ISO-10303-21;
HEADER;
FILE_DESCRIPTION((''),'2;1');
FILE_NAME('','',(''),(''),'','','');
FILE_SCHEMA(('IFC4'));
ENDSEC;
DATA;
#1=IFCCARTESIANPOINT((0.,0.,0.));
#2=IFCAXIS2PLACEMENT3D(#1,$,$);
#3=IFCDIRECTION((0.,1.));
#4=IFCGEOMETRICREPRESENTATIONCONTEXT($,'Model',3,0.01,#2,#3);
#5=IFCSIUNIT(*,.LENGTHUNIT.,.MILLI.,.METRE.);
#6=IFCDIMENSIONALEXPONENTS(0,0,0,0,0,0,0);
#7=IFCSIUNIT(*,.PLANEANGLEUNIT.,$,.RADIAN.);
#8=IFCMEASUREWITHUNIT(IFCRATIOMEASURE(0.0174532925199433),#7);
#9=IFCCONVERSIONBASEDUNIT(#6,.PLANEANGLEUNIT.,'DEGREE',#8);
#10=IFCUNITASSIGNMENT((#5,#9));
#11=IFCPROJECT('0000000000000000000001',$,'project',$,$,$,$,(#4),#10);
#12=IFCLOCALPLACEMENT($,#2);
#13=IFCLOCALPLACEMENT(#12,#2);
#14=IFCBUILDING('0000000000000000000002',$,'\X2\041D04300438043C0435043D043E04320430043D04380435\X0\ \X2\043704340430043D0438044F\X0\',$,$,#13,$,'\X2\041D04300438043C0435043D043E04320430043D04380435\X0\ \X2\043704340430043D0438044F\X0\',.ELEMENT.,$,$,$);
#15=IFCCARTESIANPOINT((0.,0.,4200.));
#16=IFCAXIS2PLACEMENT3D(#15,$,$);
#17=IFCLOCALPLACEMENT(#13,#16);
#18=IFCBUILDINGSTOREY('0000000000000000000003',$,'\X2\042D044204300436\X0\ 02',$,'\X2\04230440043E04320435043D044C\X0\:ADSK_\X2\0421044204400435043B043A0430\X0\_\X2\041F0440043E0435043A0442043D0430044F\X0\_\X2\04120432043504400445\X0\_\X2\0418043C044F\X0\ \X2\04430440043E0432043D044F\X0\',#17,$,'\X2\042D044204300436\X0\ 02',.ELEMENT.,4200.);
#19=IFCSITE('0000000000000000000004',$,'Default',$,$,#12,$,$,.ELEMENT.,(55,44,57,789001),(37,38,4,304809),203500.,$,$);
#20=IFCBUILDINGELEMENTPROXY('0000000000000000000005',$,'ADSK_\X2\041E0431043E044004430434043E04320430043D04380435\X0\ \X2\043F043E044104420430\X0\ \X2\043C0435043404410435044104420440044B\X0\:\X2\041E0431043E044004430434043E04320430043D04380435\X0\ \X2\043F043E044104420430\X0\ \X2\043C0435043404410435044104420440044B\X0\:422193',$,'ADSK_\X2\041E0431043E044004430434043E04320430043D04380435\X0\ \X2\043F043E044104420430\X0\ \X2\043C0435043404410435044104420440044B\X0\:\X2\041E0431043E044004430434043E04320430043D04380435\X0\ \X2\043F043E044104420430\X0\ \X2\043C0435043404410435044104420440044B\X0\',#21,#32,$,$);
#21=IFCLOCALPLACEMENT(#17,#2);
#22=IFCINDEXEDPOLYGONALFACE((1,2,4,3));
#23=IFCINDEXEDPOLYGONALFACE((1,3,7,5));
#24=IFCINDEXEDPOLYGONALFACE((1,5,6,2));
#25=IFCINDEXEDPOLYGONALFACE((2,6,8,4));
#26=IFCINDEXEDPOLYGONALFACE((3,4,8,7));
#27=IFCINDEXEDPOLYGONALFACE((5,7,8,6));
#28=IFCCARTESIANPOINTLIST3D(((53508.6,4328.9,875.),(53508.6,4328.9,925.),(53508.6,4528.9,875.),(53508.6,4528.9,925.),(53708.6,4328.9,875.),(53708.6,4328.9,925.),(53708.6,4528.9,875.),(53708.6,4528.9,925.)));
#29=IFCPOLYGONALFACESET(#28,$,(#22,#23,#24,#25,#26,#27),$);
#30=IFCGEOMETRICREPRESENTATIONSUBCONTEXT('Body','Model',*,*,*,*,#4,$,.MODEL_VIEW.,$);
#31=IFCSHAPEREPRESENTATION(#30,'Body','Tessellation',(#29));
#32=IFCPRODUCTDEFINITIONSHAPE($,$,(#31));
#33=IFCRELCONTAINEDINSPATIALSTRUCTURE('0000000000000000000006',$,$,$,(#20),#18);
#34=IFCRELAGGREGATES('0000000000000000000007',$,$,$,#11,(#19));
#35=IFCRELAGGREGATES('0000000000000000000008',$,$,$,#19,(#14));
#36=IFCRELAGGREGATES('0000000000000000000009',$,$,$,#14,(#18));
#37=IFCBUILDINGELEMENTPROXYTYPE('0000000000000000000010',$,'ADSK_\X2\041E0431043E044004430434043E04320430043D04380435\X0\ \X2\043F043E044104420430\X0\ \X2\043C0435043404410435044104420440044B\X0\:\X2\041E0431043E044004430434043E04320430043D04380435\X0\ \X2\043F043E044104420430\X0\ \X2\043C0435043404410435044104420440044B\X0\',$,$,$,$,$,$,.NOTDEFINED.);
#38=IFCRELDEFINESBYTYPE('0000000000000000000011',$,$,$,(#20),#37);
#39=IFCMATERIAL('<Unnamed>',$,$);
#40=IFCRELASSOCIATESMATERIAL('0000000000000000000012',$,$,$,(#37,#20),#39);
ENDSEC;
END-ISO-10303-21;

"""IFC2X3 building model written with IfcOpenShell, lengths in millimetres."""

from ifc_helpers import new_model, entity, si_unit, converted_unit, direction, frame, origin, origin_2d_with_axis, place, context, subcontext, project, spatial, rectangle, extrude, source, transform, mapped, material, type_object, type_shapes, element, save


model = new_model("IFC2X3")

# Units and contexts
model_context = context("Model", 3, precision=0.01, world=origin(), true_north=direction((0.0, 1.0)))
body_context = subcontext(model_context, "Body", "Model", "MODEL_VIEW")
ifc_project = project(units=[si_unit("LENGTHUNIT", "METRE", prefix="MILLI"), converted_unit("PLANEANGLEUNIT", "DEGREE", entity("IfcRatioMeasure", 0.0174532925199433), si_unit("PLANEANGLEUNIT", "RADIAN"), dimensions=[0, 0, 0, 0, 0, 0, 0])], contexts=[model_context])

# Site, building, storey
site_placement = place(None, origin())
site = spatial("IfcSite", under=ifc_project, at=site_placement, Name="Default", CompositionType="ELEMENT", RefLatitude=(55, 44, 57, 789001), RefLongitude=(37, 38, 4, 304809), RefElevation=203500.0)
building_placement = place(site_placement, origin())
building = spatial("IfcBuilding", under=site, at=building_placement, Name="Наименование здания", LongName="Наименование здания", CompositionType="ELEMENT")
storey_placement = place(building_placement, frame((0.0, 0.0, 4200.0)))
storey = spatial("IfcBuildingStorey", under=building, at=storey_placement, Name="Этаж 02", ObjectType="Уровень:ADSK_Стрелка_Проектная_Вверх_Имя уровня", LongName="Этаж 02", CompositionType="ELEMENT", Elevation=4200.0)

# Building element proxy
ifc_material_1 = material(Name="<Unnamed>")
building_element_proxy_type_1 = type_object("IfcBuildingElementProxyType", Name="ADSK_Оборудование поста медсестры:Оборудование поста медсестры", PredefinedType="NOTDEFINED", material=ifc_material_1)
shared_shape_1 = source(origin(), body_context, "Body", "SweptSolid", [
    extrude(rectangle(XDim=200.0, YDim=200.0, at=origin_2d_with_axis()), frame((0.0, -68.0, -25.0), z_axis=(0.0, 0.0, 1.0), x_axis=(-1.0, 0.0, 0.0)), (0.0, 0.0, 1.0), 50.0),
])
type_shapes(building_element_proxy_type_1, [shared_shape_1])
proxy_1_placement = place(storey_placement, frame((53608.6, 4496.9, 900.0)))
element("IfcBuildingElementProxy", 1, at=proxy_1_placement, inside=storey, type_object=building_element_proxy_type_1, material=ifc_material_1, Name="ADSK_Оборудование поста медсестры:Оборудование поста медсестры:422193", ObjectType="ADSK_Оборудование поста медсестры:Оборудование поста медсестры", context=body_context, shape_type="MappedRepresentation", body=[
    mapped(shared_shape_1, transform((0.0, 0.0, 0.0), scale=1.0)),
])

save(model, "model.ifc")
